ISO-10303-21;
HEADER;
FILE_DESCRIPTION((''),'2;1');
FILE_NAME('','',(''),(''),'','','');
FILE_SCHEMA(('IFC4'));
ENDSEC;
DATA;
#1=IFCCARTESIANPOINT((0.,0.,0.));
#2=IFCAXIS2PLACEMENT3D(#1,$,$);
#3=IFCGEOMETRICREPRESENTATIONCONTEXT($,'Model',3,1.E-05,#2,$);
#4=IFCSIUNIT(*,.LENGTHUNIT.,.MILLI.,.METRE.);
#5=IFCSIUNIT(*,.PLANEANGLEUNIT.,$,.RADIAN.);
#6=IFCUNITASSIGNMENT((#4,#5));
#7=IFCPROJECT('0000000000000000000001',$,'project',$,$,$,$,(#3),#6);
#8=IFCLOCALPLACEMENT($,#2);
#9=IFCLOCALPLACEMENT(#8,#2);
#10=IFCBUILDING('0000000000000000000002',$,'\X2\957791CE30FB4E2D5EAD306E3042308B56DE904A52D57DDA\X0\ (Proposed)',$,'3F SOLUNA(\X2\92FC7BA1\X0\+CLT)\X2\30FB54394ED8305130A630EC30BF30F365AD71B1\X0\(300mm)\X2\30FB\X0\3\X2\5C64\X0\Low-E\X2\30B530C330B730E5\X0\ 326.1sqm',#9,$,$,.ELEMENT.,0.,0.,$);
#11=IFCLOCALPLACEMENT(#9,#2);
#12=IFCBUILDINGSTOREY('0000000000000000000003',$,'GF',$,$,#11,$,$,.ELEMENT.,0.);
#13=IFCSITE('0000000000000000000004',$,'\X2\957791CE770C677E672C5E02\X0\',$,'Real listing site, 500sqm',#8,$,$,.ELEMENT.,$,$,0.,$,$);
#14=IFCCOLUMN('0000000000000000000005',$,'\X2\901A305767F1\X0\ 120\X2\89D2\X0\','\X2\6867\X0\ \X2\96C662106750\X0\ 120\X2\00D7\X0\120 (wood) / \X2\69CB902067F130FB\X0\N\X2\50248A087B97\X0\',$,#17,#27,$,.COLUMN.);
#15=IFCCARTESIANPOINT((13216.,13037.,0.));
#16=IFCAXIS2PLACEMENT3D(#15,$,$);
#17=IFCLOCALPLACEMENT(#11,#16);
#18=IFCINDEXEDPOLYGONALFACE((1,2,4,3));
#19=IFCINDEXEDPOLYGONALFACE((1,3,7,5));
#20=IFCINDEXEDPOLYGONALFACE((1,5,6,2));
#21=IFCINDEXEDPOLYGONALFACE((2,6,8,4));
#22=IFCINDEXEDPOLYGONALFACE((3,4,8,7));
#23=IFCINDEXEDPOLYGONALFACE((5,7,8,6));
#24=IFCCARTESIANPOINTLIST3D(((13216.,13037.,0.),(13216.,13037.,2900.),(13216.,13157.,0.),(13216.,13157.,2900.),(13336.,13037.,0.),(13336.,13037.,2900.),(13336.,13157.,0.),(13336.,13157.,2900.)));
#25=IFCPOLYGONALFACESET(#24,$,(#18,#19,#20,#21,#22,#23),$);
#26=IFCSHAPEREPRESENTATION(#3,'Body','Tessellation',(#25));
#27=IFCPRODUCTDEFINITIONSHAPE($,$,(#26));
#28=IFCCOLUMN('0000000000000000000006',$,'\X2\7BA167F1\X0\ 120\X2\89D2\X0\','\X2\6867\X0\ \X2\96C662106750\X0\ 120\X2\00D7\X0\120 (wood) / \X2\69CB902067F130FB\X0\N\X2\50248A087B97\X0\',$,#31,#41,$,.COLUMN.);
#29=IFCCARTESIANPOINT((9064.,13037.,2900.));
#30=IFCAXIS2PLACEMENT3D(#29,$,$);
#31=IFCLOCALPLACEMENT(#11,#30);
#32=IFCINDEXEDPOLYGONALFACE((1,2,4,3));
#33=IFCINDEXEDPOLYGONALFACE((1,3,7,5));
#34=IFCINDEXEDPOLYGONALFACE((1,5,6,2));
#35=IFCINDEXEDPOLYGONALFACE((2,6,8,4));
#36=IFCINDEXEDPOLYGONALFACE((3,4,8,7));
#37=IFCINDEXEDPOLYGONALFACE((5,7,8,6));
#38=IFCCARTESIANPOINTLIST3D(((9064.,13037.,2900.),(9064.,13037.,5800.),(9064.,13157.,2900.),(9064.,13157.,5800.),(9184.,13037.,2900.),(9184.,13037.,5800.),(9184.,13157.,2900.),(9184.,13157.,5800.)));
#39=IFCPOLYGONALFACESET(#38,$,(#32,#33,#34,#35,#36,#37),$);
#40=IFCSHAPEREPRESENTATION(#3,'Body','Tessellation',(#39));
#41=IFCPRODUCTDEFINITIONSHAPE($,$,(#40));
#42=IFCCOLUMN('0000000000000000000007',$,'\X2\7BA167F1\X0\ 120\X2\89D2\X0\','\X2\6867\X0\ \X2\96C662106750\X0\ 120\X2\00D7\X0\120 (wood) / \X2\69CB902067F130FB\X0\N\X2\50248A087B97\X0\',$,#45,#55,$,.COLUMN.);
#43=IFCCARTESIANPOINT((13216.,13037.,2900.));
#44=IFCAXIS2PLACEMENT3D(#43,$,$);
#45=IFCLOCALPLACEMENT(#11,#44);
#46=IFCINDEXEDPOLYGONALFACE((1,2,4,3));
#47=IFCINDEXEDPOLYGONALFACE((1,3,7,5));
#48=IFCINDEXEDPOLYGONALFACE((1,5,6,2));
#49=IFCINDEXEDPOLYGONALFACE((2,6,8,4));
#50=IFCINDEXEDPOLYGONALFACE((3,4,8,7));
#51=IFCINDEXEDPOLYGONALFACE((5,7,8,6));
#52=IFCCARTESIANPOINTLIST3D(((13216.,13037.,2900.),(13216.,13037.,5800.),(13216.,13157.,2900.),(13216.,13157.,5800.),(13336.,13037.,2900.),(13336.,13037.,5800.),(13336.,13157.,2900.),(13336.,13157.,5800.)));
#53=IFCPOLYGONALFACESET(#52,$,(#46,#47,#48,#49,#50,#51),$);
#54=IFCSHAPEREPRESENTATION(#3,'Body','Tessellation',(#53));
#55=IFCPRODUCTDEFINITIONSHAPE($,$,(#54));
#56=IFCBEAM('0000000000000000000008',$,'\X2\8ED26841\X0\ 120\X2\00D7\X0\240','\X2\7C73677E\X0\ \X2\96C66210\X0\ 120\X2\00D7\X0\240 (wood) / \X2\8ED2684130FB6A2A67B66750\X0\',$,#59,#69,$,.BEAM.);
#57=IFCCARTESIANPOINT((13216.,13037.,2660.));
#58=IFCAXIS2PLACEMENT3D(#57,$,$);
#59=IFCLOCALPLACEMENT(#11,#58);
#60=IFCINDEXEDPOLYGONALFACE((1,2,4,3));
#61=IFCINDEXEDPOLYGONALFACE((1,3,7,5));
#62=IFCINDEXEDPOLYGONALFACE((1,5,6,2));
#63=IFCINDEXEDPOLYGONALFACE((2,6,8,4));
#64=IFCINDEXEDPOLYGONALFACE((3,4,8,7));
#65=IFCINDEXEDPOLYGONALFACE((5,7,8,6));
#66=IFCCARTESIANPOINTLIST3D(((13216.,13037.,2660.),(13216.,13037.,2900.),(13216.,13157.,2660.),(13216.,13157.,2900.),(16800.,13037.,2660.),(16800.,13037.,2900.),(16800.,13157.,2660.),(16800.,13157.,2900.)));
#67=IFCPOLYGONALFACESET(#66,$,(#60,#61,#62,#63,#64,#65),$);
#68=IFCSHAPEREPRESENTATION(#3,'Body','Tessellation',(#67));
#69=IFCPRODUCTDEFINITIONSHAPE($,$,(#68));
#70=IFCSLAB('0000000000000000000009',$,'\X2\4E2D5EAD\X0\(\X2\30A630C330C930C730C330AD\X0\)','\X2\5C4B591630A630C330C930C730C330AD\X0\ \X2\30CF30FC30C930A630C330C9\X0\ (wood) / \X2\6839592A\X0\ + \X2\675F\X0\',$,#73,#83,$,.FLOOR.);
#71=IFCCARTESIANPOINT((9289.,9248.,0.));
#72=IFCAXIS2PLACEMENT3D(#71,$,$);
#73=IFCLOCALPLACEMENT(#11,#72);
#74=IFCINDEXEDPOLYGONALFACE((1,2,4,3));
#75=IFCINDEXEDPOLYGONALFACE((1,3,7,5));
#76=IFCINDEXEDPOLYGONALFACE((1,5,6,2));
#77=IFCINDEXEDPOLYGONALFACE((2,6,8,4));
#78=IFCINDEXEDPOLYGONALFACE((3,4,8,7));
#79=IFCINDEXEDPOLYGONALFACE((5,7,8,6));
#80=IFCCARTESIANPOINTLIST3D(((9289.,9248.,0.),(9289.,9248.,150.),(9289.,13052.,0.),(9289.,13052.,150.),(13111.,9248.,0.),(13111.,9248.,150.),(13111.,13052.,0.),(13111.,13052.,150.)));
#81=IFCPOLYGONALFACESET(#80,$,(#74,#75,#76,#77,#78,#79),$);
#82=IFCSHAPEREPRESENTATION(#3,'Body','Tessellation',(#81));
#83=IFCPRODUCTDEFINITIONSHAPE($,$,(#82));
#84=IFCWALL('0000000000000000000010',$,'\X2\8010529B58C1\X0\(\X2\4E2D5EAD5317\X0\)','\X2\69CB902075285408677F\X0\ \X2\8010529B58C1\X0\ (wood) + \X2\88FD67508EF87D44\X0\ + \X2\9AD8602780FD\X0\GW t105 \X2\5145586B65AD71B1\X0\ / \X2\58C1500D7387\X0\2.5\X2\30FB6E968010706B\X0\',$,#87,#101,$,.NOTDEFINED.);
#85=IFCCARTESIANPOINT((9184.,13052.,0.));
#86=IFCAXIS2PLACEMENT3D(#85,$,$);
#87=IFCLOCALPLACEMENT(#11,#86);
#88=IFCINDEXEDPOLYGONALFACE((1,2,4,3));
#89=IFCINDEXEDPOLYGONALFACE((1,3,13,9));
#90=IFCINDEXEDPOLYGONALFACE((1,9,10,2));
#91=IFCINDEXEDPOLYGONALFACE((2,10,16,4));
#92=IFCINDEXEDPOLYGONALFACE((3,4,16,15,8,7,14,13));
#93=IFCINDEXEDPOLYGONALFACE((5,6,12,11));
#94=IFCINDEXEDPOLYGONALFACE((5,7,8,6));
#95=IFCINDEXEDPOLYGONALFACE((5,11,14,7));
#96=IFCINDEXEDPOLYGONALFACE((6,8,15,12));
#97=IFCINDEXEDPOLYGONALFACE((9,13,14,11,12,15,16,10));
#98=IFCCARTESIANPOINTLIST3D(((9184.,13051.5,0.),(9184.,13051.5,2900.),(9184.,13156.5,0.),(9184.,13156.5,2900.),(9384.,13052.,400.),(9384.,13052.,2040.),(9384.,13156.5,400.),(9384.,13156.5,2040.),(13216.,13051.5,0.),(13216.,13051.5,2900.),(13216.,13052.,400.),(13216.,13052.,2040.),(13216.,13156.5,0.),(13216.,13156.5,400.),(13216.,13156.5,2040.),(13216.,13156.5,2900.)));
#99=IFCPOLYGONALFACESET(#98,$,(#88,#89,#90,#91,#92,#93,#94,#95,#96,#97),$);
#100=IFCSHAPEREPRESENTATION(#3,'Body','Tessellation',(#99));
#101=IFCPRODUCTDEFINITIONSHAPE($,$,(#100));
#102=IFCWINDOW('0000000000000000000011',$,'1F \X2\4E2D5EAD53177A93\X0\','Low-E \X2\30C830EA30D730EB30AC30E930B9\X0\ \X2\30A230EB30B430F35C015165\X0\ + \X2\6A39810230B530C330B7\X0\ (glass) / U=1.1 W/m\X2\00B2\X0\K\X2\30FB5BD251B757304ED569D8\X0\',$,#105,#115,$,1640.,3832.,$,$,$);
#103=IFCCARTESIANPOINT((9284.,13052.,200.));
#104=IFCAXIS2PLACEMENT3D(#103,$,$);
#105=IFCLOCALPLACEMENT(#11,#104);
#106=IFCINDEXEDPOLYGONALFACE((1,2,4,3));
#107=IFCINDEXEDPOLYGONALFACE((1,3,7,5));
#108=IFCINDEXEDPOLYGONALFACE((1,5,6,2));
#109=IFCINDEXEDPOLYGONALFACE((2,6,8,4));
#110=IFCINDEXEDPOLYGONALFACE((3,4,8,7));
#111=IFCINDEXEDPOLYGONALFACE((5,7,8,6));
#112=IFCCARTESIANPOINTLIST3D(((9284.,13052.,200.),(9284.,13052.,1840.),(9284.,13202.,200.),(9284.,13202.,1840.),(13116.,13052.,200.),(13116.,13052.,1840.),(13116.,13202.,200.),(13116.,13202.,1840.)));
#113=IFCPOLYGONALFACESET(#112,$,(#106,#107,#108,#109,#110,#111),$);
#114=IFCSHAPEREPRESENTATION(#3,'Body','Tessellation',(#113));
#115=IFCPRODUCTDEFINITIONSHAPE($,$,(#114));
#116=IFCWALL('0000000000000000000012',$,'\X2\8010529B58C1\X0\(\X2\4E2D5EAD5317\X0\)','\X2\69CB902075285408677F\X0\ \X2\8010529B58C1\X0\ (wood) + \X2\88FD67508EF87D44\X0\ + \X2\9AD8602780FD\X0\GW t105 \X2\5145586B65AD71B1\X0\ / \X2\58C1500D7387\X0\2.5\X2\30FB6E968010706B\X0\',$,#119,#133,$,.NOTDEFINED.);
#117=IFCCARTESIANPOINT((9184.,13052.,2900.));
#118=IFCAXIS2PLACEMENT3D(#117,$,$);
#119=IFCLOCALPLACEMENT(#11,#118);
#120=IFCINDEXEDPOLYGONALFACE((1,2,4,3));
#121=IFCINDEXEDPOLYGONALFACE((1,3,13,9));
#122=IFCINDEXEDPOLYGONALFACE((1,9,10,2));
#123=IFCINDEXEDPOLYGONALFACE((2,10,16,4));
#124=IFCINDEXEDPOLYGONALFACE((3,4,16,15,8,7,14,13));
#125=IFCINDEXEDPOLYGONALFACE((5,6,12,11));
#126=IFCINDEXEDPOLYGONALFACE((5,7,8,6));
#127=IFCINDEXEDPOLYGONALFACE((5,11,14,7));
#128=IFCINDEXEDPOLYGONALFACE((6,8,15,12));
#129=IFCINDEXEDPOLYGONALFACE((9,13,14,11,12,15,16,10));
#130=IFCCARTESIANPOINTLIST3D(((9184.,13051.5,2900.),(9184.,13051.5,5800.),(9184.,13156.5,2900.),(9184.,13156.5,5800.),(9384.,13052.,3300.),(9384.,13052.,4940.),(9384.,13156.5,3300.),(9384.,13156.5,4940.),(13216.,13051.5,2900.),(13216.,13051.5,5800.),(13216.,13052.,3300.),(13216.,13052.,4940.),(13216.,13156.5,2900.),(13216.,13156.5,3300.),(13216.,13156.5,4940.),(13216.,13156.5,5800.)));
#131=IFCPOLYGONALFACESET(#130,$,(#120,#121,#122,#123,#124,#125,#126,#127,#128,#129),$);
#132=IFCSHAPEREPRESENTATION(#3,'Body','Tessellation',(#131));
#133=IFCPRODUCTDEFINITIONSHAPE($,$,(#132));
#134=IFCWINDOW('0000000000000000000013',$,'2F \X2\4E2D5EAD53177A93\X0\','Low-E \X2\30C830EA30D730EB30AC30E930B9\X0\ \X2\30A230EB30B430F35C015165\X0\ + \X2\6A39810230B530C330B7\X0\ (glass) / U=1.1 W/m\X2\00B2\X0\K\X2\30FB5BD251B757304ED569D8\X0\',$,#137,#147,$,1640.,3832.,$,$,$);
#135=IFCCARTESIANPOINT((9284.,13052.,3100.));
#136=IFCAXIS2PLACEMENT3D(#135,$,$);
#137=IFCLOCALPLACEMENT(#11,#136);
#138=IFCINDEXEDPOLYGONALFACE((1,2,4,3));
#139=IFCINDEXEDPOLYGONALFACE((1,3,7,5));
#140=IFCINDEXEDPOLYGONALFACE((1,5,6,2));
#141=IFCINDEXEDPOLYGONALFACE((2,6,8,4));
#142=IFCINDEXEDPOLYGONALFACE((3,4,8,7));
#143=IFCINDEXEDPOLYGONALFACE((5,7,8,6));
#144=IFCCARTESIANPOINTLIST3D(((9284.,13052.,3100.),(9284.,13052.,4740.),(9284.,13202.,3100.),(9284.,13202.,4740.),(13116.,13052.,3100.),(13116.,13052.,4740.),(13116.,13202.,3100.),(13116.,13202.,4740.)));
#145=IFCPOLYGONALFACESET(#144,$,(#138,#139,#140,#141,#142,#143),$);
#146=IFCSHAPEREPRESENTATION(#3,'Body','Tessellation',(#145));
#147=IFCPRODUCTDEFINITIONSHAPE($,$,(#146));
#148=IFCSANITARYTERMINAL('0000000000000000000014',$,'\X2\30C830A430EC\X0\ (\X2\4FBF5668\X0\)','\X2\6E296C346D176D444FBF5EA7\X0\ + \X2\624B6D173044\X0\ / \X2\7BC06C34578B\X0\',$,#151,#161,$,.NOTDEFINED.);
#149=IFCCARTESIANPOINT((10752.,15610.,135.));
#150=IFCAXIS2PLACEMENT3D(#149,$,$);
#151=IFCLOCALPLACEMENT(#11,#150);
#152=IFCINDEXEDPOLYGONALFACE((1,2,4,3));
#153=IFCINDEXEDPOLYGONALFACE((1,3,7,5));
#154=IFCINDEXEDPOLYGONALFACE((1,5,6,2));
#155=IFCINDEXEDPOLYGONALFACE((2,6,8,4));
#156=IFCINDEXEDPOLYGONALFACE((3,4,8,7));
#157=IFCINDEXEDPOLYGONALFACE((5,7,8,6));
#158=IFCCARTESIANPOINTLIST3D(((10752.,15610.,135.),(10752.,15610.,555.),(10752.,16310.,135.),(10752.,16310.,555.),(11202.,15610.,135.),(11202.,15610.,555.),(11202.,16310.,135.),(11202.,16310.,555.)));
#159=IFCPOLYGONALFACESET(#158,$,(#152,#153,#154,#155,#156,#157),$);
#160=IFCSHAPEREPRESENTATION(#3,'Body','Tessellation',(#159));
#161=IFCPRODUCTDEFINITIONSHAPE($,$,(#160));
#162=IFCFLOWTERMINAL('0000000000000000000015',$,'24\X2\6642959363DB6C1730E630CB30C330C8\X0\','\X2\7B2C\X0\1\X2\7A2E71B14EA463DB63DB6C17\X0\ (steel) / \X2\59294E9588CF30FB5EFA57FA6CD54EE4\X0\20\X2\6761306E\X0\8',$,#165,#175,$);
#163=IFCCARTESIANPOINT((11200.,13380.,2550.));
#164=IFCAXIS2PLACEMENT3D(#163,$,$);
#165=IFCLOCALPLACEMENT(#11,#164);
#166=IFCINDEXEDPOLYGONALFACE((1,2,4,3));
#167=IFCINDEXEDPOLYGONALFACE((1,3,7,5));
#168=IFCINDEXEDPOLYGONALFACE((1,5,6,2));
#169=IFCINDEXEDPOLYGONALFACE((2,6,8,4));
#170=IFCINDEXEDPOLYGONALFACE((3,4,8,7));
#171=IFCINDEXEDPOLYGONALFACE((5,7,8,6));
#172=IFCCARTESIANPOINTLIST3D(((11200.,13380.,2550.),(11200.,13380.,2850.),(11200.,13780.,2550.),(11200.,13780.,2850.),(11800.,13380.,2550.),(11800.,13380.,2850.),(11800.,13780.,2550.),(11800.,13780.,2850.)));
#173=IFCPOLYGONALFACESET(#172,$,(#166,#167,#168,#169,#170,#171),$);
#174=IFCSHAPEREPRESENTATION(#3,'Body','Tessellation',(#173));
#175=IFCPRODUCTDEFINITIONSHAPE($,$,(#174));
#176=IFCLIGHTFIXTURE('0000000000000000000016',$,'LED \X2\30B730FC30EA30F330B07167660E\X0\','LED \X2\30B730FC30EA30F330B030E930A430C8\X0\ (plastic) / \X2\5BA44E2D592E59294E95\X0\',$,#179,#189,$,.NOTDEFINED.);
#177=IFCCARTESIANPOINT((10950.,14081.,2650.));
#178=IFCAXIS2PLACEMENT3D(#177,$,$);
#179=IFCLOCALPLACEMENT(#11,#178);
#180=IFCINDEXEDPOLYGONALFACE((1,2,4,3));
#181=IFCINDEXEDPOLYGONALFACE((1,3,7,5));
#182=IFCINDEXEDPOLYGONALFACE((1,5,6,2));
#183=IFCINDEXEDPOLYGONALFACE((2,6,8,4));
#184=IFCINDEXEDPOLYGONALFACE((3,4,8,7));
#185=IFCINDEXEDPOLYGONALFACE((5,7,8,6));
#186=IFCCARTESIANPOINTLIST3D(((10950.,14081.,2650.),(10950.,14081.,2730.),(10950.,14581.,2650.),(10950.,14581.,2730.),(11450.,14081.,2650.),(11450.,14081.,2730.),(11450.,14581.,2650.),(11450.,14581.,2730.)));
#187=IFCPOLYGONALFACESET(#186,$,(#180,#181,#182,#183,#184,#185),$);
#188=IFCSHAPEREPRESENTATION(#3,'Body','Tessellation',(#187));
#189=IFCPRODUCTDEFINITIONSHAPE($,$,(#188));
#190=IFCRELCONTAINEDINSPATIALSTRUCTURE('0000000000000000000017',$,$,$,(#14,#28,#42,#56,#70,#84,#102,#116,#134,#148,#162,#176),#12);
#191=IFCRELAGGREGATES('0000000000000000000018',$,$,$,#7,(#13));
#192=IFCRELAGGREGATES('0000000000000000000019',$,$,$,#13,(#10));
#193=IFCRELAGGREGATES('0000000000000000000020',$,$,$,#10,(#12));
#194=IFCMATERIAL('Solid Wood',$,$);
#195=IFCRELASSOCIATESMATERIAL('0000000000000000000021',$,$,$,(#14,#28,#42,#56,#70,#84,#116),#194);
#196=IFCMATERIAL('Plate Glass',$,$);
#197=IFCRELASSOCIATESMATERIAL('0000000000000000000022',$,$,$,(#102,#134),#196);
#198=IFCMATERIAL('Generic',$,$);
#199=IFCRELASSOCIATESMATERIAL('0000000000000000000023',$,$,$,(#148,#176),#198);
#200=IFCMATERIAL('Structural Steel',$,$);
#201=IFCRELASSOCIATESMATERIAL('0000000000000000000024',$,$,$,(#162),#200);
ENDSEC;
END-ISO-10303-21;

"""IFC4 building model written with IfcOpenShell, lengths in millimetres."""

from ifc_helpers import new_model, si_unit, frame, frame_2d, origin, place, context, project, spatial, rectangle, extrude, material, element, fill, save


model = new_model("IFC4")

# Units and contexts
model_context = context("Model", 3, precision=1e-05, world=origin())
ifc_project = project(units=[si_unit("LENGTHUNIT", "METRE", prefix="MILLI"), si_unit("PLANEANGLEUNIT", "RADIAN")], contexts=[model_context])

# Site, building, storey
site_placement = place(None, origin())
site = spatial("IfcSite", under=ifc_project, at=site_placement, Name="長野県松本市", ObjectType="Real listing site, 500sqm", CompositionType="ELEMENT", RefElevation=0.0)
building_placement = place(site_placement, origin())
building = spatial("IfcBuilding", under=site, at=building_placement, Name="長野・中庭のある回遊動線 (Proposed)", ObjectType="3F SOLUNA(鋼管+CLT)・吹付けウレタン断熱(300mm)・3層Low-Eサッシュ 326.1sqm", CompositionType="ELEMENT", ElevationOfRefHeight=0.0, ElevationOfTerrain=0.0)
storey_placement = place(building_placement, origin())
storey = spatial("IfcBuildingStorey", under=building, at=storey_placement, Name="GF", CompositionType="ELEMENT", Elevation=0.0)

# Columns
ifc_material_1 = material(Name="Solid Wood")
column_1_placement = place(storey_placement, frame((13216.0, 13037.0, 0.0)))
element("IfcColumn", 1, at=column_1_placement, inside=storey, material=ifc_material_1, Name="通し柱 120角", Description="桧 集成材 120×120 (wood) / 構造柱・N値計算", PredefinedType="COLUMN", context=model_context, shape_type="SweptSolid", body=[
    extrude(rectangle(XDim=120.0, YDim=120.0, at=frame_2d((60.0, 60.0))), frame((13216.0, 13037.0, 0.0)), (0.0, 0.0, 1.0), 2900.0),
])
column_2_placement = place(storey_placement, frame((9064.0, 13037.0, 2900.0)))
element("IfcColumn", 2, at=column_2_placement, inside=storey, material=ifc_material_1, Name="管柱 120角", Description="桧 集成材 120×120 (wood) / 構造柱・N値計算", PredefinedType="COLUMN", context=model_context, shape_type="SweptSolid", body=[
    extrude(rectangle(XDim=120.0, YDim=120.0, at=frame_2d((60.0, 60.0))), frame((9064.0, 13037.0, 2900.0)), (0.0, 0.0, 1.0), 2900.0),
])
column_3_placement = place(storey_placement, frame((13216.0, 13037.0, 2900.0)))
element("IfcColumn", 3, at=column_3_placement, inside=storey, material=ifc_material_1, Name="管柱 120角", Description="桧 集成材 120×120 (wood) / 構造柱・N値計算", PredefinedType="COLUMN", context=model_context, shape_type="SweptSolid", body=[
    extrude(rectangle(XDim=120.0, YDim=120.0, at=frame_2d((60.0, 60.0))), frame((13216.0, 13037.0, 2900.0)), (0.0, 0.0, 1.0), 2900.0),
])

# Beam
beam_1_placement = place(storey_placement, frame((13216.0, 13037.0, 2660.0)))
element("IfcBeam", 4, at=beam_1_placement, inside=storey, material=ifc_material_1, Name="軒桁 120×240", Description="米松 集成 120×240 (wood) / 軒桁・横架材", PredefinedType="BEAM", context=model_context, shape_type="SweptSolid", body=[
    extrude(rectangle(XDim=3584.0, YDim=120.0, at=frame_2d((1792.0, 60.0))), frame((13216.0, 13037.0, 2660.0)), (0.0, 0.0, 1.0), 240.0),
])

# Slab
slab_placement = place(storey_placement, frame((9289.0, 9248.0, 0.0)))
element("IfcSlab", 5, at=slab_placement, inside=storey, material=ifc_material_1, Name="中庭(ウッドデッキ)", Description="屋外ウッドデッキ ハードウッド (wood) / 根太 + 束", PredefinedType="FLOOR", context=model_context, shape_type="SweptSolid", body=[
    extrude(rectangle(XDim=3822.0, YDim=3804.0, at=frame_2d((1911.0, 1902.0))), frame((9289.0, 9248.0, 0.0)), (0.0, 0.0, 1.0), 150.0),
])

# Wall, opening, window
wall_1_placement = place(storey_placement, frame((9184.0, 13052.0, 0.0)))
wall_1 = element("IfcWall", 6, at=wall_1_placement, inside=storey, material=ifc_material_1, Name="耐力壁(中庭北)", Description="構造用合板 耐力壁 (wood) + 製材軸組 + 高性能GW t105 充填断熱 / 壁倍率2.5・準耐火", PredefinedType="NOTDEFINED", context=model_context, shape_type="SweptSolid", body=[
    extrude(rectangle(XDim=4032.0, YDim=105.0, at=frame_2d((2016.0, 52.0))), frame((9184.0, 13052.0, 0.0)), (0.0, 0.0, 1.0), 2900.0),
])
opening_1_placement = place(storey_placement, frame((9284.0, 13052.0, 200.0)))
opening_1 = element("IfcOpeningElement", 7, at=opening_1_placement, cuts=wall_1, PredefinedType="NOTDEFINED", context=model_context, shape_type="SweptSolid", body=[
    extrude(rectangle(XDim=3832.0, YDim=150.0, at=frame_2d((1916.0, 75.0))), frame((9284.0, 13052.0, 200.0)), (0.0, 0.0, 1.0), 1640.0),
])
ifc_material_2 = material(Name="Plate Glass")
window_1_placement = place(storey_placement, frame((9284.0, 13052.0, 200.0)))
window_1 = element("IfcWindow", 8, at=window_1_placement, inside=storey, material=ifc_material_2, Name="1F 中庭北窓", Description="Low-E トリプルガラス アルゴン封入 + 樹脂サッシ (glass) / U=1.1 W/m²K・寒冷地仕様", OverallHeight=1640.0, OverallWidth=3832.0, context=model_context, shape_type="SweptSolid", body=[
    extrude(rectangle(XDim=3832.0, YDim=150.0, at=frame_2d((1916.0, 75.0))), frame((9284.0, 13052.0, 200.0)), (0.0, 0.0, 1.0), 1640.0),
])
fill(opening_1, window_1)

# Wall, opening, window
wall_2_placement = place(storey_placement, frame((9184.0, 13052.0, 2900.0)))
wall_2 = element("IfcWall", 9, at=wall_2_placement, inside=storey, material=ifc_material_1, Name="耐力壁(中庭北)", Description="構造用合板 耐力壁 (wood) + 製材軸組 + 高性能GW t105 充填断熱 / 壁倍率2.5・準耐火", PredefinedType="NOTDEFINED", context=model_context, shape_type="SweptSolid", body=[
    extrude(rectangle(XDim=4032.0, YDim=105.0, at=frame_2d((2016.0, 52.0))), frame((9184.0, 13052.0, 2900.0)), (0.0, 0.0, 1.0), 2900.0),
])
opening_2_placement = place(storey_placement, frame((9284.0, 13052.0, 3100.0)))
opening_2 = element("IfcOpeningElement", 10, at=opening_2_placement, cuts=wall_2, PredefinedType="NOTDEFINED", context=model_context, shape_type="SweptSolid", body=[
    extrude(rectangle(XDim=3832.0, YDim=150.0, at=frame_2d((1916.0, 75.0))), frame((9284.0, 13052.0, 3100.0)), (0.0, 0.0, 1.0), 1640.0),
])
window_2_placement = place(storey_placement, frame((9284.0, 13052.0, 3100.0)))
window_2 = element("IfcWindow", 11, at=window_2_placement, inside=storey, material=ifc_material_2, Name="2F 中庭北窓", Description="Low-E トリプルガラス アルゴン封入 + 樹脂サッシ (glass) / U=1.1 W/m²K・寒冷地仕様", OverallHeight=1640.0, OverallWidth=3832.0, context=model_context, shape_type="SweptSolid", body=[
    extrude(rectangle(XDim=3832.0, YDim=150.0, at=frame_2d((1916.0, 75.0))), frame((9284.0, 13052.0, 3100.0)), (0.0, 0.0, 1.0), 1640.0),
])
fill(opening_2, window_2)

# Sanitary terminal
ifc_material_3 = material(Name="Generic")
sanitary_terminal_placement = place(storey_placement, frame((10752.0, 15610.0, 135.0)))
element("IfcSanitaryTerminal", 12, at=sanitary_terminal_placement, inside=storey, material=ifc_material_3, Name="トイレ (便器)", Description="温水洗浄便座 + 手洗い / 節水型", PredefinedType="NOTDEFINED", context=model_context, shape_type="SweptSolid", body=[
    extrude(rectangle(XDim=450.0, YDim=700.0, at=frame_2d((225.0, 350.0))), frame((10752.0, 15610.0, 135.0)), (0.0, 0.0, 1.0), 420.0),
])

# Flow terminal
ifc_material_4 = material(Name="Structural Steel")
flow_terminal_placement = place(storey_placement, frame((11200.0, 13380.0, 2550.0)))
element("IfcFlowTerminal", 13, at=flow_terminal_placement, inside=storey, material=ifc_material_4, Name="24時間換気ユニット", Description="第1種熱交換換気 (steel) / 天井裏・建基法令20条の8", context=model_context, shape_type="SweptSolid", body=[
    extrude(rectangle(XDim=600.0, YDim=400.0, at=frame_2d((300.0, 200.0))), frame((11200.0, 13380.0, 2550.0)), (0.0, 0.0, 1.0), 300.0),
])

# Light fixture
light_fixture_placement = place(storey_placement, frame((10950.0, 14081.0, 2650.0)))
element("IfcLightFixture", 14, at=light_fixture_placement, inside=storey, material=ifc_material_3, Name="LED シーリング照明", Description="LED シーリングライト (plastic) / 室中央天井", PredefinedType="NOTDEFINED", context=model_context, shape_type="SweptSolid", body=[
    extrude(rectangle(XDim=500.0, YDim=500.0, at=frame_2d((250.0, 250.0))), frame((10950.0, 14081.0, 2650.0)), (0.0, 0.0, 1.0), 80.0),
])

save(model, "model.ifc")
